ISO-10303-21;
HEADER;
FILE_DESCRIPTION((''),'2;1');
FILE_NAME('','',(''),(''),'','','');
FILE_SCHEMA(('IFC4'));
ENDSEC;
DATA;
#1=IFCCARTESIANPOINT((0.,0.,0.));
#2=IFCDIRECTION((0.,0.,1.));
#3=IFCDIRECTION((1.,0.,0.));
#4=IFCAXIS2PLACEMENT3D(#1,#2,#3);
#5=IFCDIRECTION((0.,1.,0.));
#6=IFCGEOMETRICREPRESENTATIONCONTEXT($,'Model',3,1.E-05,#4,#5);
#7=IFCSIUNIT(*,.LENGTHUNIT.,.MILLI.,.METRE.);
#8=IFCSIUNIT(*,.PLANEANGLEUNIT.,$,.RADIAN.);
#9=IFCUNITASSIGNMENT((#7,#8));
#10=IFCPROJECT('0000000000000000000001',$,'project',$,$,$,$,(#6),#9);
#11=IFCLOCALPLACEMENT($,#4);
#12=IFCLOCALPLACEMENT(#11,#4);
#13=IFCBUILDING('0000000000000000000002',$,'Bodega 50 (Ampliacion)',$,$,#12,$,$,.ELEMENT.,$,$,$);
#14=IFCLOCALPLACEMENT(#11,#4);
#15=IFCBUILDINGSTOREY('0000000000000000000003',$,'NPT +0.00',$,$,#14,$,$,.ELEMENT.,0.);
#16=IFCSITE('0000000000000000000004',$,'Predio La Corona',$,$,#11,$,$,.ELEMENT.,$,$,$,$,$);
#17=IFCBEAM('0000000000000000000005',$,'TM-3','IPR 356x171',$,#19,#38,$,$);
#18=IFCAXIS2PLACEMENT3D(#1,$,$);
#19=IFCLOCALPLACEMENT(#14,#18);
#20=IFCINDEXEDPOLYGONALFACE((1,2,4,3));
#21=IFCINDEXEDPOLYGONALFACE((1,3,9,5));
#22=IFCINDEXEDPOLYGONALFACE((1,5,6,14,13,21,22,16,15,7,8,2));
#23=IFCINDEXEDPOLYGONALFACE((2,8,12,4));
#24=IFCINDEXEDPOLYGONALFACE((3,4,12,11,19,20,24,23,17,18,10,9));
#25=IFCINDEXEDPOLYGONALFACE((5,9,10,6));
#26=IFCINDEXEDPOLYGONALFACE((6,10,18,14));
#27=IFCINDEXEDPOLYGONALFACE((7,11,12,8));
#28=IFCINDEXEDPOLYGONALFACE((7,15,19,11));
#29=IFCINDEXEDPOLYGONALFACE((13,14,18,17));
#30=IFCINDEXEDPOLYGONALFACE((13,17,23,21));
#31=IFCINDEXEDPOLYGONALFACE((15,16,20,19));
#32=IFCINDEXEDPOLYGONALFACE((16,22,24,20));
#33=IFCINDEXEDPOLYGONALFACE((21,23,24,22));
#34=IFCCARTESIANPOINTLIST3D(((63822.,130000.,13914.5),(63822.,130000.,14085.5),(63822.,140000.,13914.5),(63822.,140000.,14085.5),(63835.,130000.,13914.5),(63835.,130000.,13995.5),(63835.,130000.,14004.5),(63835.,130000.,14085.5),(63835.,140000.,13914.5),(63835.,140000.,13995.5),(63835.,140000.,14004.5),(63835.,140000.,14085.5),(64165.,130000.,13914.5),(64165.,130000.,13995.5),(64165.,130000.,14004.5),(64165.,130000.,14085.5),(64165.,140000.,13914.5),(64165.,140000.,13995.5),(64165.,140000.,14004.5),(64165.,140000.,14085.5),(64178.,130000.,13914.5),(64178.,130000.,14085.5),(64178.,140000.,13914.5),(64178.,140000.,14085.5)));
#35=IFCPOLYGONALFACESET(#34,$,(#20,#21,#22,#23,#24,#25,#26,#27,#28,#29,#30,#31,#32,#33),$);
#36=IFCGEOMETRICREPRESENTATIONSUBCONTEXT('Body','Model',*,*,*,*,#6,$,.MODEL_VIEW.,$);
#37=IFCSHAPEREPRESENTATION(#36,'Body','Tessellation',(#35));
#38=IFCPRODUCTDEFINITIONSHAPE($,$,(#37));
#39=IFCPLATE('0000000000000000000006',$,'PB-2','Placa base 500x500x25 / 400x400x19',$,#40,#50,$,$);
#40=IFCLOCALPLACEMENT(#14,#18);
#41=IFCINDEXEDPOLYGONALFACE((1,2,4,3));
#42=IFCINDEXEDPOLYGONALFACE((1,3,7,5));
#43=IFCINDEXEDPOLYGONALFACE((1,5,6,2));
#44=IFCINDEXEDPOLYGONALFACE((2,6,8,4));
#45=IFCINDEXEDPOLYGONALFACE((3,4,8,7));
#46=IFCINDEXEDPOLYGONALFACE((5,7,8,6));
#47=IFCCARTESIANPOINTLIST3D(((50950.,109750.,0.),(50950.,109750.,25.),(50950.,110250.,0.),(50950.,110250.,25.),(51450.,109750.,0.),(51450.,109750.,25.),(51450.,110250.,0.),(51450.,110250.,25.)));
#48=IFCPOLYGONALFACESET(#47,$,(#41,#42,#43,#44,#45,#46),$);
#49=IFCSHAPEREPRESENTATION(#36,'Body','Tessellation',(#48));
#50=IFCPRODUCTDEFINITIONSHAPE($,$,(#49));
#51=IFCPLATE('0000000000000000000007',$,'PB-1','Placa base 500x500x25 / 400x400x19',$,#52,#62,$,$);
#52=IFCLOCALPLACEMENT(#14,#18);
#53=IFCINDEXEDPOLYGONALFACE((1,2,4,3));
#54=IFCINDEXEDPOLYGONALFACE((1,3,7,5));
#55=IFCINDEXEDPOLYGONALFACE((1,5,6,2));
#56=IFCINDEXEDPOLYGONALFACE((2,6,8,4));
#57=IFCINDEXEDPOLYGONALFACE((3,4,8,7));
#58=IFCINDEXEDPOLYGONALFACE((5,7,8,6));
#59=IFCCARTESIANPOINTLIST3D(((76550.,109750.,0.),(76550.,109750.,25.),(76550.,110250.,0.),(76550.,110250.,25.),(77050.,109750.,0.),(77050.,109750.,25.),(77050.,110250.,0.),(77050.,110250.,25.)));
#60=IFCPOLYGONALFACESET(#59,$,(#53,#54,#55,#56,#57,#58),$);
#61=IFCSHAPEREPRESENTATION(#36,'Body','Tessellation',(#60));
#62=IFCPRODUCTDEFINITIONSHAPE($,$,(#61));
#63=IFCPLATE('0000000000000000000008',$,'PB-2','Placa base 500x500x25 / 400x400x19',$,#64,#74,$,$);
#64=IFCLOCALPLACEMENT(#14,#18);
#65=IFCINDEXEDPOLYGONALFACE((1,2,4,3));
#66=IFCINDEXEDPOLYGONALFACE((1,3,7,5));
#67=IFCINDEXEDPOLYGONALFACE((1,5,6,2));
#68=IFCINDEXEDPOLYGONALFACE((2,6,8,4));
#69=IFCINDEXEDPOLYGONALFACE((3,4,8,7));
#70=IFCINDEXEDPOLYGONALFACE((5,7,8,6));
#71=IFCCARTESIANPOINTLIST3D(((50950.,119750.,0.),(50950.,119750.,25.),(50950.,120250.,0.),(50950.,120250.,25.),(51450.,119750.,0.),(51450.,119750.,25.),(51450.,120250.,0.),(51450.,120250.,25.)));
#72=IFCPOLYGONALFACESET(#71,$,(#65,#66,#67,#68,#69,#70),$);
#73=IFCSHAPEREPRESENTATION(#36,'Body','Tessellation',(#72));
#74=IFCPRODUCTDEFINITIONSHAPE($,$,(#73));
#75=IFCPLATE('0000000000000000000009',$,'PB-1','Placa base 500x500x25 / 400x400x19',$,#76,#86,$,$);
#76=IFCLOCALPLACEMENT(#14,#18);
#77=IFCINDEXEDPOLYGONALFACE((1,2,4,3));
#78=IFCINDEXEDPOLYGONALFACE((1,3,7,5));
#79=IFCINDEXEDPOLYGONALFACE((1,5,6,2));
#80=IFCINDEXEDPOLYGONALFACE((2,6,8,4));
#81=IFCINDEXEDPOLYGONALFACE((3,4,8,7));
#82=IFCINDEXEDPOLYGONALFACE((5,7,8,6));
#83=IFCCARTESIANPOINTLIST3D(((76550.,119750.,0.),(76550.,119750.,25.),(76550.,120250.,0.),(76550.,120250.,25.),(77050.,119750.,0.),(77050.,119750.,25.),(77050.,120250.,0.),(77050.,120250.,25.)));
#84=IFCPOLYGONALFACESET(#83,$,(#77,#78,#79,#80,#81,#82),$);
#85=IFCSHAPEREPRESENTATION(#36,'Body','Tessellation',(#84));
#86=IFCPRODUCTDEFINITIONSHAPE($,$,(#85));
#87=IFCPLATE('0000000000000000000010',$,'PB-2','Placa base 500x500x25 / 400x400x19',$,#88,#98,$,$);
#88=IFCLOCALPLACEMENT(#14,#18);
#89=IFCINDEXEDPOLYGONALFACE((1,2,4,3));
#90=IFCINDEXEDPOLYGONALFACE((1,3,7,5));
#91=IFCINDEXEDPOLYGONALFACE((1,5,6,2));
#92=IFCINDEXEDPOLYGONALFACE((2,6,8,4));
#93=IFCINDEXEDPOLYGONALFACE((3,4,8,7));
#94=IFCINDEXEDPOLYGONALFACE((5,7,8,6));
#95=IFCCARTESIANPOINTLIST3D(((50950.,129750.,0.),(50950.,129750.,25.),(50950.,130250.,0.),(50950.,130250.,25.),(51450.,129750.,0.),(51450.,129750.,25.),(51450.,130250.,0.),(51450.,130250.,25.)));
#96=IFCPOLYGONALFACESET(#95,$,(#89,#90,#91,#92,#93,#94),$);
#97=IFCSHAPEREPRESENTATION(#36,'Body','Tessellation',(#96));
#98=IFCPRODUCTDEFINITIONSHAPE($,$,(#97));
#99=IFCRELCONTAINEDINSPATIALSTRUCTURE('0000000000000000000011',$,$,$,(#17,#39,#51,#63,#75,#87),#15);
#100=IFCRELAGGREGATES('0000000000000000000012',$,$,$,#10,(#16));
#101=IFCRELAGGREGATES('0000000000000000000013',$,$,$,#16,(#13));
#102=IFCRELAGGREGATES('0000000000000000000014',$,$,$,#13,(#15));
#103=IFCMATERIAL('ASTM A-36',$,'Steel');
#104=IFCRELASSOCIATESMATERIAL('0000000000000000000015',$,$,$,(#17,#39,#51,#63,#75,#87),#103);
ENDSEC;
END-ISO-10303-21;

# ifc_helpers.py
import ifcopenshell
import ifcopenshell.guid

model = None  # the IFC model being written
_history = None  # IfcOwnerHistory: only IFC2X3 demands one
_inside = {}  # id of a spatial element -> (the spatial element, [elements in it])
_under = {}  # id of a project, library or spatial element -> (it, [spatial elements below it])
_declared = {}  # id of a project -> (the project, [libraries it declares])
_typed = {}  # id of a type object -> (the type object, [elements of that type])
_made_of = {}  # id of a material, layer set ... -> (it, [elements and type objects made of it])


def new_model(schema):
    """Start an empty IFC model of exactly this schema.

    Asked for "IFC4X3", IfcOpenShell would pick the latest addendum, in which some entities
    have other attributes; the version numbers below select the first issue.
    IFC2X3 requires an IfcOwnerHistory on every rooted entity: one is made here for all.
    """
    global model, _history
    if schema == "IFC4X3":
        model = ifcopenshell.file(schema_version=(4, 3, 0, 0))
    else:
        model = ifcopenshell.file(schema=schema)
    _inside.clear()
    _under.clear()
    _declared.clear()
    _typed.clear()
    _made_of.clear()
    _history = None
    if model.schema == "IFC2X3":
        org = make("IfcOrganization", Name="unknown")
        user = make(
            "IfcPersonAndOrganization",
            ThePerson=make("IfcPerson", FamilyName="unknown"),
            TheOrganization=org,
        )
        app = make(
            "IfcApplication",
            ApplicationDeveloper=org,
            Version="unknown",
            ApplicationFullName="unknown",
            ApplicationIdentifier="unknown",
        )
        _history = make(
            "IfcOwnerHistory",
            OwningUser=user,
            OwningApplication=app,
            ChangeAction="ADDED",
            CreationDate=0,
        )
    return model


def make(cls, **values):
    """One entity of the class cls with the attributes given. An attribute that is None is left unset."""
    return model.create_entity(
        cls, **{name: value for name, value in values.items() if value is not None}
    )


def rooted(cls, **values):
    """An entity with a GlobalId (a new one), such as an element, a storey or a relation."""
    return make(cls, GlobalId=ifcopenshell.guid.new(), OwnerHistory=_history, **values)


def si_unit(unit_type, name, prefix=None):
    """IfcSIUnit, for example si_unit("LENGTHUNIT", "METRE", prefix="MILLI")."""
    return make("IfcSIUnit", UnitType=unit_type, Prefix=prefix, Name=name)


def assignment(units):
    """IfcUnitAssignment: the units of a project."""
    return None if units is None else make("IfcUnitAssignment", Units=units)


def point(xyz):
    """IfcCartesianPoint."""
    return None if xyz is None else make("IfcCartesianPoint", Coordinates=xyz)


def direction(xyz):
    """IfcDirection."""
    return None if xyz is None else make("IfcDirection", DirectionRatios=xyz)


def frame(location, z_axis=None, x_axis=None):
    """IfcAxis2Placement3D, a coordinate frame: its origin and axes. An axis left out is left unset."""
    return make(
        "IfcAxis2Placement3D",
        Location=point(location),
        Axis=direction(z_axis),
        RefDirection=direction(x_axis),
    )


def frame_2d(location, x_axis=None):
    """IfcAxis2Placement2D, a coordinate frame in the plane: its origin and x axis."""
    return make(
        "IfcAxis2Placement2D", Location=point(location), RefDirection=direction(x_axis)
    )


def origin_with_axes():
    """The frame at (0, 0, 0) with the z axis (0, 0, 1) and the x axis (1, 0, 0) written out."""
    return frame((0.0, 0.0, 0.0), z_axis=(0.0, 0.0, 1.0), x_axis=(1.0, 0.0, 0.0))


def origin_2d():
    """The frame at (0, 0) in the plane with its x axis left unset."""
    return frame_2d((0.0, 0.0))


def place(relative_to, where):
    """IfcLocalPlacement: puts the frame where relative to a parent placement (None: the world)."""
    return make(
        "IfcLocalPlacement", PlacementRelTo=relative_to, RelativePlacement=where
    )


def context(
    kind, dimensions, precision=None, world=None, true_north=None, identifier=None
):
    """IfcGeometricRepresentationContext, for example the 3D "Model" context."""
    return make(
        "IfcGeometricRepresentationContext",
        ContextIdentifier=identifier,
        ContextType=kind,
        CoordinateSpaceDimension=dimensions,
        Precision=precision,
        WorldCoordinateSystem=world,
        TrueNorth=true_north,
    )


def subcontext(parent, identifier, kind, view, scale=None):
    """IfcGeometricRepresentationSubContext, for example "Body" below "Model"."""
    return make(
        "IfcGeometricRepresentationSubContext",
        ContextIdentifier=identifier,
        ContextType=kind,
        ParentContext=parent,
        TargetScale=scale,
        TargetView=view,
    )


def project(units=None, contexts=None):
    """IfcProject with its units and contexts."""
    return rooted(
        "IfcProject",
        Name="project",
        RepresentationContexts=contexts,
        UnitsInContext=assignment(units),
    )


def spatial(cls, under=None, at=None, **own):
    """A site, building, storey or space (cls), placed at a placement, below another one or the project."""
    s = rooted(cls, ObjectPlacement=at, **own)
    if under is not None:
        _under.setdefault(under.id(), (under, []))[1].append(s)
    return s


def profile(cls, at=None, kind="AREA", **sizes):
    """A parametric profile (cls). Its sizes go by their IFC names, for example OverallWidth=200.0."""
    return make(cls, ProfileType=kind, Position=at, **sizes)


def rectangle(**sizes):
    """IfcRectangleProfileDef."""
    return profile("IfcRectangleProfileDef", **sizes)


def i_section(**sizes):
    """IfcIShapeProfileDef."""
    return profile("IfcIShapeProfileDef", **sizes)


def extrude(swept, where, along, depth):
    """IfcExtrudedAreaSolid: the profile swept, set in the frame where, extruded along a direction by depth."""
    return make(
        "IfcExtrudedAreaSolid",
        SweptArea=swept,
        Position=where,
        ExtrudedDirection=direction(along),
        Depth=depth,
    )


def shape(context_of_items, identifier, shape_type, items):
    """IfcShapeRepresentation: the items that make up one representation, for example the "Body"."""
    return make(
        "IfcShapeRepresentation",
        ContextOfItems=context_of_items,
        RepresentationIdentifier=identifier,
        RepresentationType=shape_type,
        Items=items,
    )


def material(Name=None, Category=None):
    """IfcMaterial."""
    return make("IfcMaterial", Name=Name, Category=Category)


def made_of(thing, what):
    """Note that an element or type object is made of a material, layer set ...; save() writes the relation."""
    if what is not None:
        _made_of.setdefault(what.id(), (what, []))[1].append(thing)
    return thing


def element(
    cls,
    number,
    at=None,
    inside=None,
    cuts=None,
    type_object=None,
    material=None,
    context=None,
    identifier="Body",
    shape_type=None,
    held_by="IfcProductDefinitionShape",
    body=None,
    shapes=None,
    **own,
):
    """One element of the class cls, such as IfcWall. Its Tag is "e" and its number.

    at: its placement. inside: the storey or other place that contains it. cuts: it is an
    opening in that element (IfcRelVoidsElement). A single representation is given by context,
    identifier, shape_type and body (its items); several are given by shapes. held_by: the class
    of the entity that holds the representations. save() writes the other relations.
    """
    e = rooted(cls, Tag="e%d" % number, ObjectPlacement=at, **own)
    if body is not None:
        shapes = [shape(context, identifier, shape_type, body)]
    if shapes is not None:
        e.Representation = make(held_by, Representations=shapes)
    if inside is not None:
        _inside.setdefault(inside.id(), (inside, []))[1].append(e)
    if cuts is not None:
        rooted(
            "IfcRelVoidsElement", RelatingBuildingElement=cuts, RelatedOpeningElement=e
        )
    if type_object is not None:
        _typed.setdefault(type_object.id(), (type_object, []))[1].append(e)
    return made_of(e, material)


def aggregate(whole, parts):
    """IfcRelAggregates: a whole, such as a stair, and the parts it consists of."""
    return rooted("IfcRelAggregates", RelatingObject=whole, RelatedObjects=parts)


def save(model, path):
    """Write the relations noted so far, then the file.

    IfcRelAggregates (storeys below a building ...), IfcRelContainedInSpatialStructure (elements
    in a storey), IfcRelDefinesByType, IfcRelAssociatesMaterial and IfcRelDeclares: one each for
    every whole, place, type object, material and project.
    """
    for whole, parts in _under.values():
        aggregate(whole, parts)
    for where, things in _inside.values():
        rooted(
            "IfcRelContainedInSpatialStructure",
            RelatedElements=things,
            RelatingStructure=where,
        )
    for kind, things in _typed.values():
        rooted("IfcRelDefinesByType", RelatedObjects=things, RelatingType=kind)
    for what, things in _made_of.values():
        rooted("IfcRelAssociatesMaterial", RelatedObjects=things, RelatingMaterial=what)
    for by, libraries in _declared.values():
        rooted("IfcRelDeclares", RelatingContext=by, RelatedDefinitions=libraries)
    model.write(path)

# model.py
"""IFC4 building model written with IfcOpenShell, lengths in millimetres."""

from ifc_helpers import new_model, si_unit, direction, frame, origin_with_axes, origin_2d, place, context, subcontext, project, spatial, rectangle, i_section, extrude, material, element, save


model = new_model("IFC4")

# Units and contexts
model_context = context("Model", 3, precision=1e-05, world=origin_with_axes(), true_north=direction((0.0, 1.0, 0.0)))
body_context = subcontext(model_context, "Body", "Model", "MODEL_VIEW")
ifc_project = project(units=[si_unit("LENGTHUNIT", "METRE", prefix="MILLI"), si_unit("PLANEANGLEUNIT", "RADIAN")], contexts=[model_context])

# Site, building, storey
site_placement = place(None, origin_with_axes())
site = spatial("IfcSite", under=ifc_project, at=site_placement, Name="Predio La Corona", CompositionType="ELEMENT")
building_placement = place(site_placement, origin_with_axes())
building = spatial("IfcBuilding", under=site, at=building_placement, Name="Bodega 50 (Ampliacion)", CompositionType="ELEMENT")
storey_placement = place(site_placement, origin_with_axes())
storey = spatial("IfcBuildingStorey", under=building, at=storey_placement, Name="NPT +0.00", CompositionType="ELEMENT", Elevation=0.0)

# Shared definitions
ifc_material = material(Name="ASTM A-36", Category="Steel")

# Beam
for number, where, z_axis, x_axis, name in (
    (1, (64000.0, 130000.0, 14000.0), (0.0, 1.0, 0.0), (0.0, 0.0, 1.0), "TM-3"),
):
    element("IfcBeam", number, at=place(storey_placement, frame(where, z_axis=z_axis, x_axis=x_axis)), inside=storey, material=ifc_material, Name=name, Description="IPR 356x171", context=body_context, shape_type="SweptSolid", body=[
        extrude(i_section(OverallWidth=171.0, OverallDepth=356.0, WebThickness=9.0, FlangeThickness=13.0, at=origin_2d()), origin_with_axes(), (0.0, 0.0, 1.0), 10000.0),
    ])

# Plates
for number, where, z_axis, x_axis, name in (
    (2, (51200.0, 110000.0, 0.0), (0.0, 0.0, 1.0), (1.0, 0.0, 0.0), "PB-2"),
    (3, (76800.0, 110000.0, 0.0), (0.0, 0.0, 1.0), (1.0, 0.0, 0.0), "PB-1"),
    (4, (51200.0, 120000.0, 0.0), (0.0, 0.0, 1.0), (1.0, 0.0, 0.0), "PB-2"),
    (5, (76800.0, 120000.0, 0.0), (0.0, 0.0, 1.0), (1.0, 0.0, 0.0), "PB-1"),
    (6, (51200.0, 130000.0, 0.0), (0.0, 0.0, 1.0), (1.0, 0.0, 0.0), "PB-2"),
):
    element("IfcPlate", number, at=place(storey_placement, frame(where, z_axis=z_axis, x_axis=x_axis)), inside=storey, material=ifc_material, Name=name, Description="Placa base 500x500x25 / 400x400x19", context=body_context, shape_type="SweptSolid", body=[
        extrude(rectangle(XDim=500.0, YDim=500.0, at=origin_2d()), origin_with_axes(), (0.0, 0.0, 1.0), 25.0),
    ])

save(model, "model.ifc")
